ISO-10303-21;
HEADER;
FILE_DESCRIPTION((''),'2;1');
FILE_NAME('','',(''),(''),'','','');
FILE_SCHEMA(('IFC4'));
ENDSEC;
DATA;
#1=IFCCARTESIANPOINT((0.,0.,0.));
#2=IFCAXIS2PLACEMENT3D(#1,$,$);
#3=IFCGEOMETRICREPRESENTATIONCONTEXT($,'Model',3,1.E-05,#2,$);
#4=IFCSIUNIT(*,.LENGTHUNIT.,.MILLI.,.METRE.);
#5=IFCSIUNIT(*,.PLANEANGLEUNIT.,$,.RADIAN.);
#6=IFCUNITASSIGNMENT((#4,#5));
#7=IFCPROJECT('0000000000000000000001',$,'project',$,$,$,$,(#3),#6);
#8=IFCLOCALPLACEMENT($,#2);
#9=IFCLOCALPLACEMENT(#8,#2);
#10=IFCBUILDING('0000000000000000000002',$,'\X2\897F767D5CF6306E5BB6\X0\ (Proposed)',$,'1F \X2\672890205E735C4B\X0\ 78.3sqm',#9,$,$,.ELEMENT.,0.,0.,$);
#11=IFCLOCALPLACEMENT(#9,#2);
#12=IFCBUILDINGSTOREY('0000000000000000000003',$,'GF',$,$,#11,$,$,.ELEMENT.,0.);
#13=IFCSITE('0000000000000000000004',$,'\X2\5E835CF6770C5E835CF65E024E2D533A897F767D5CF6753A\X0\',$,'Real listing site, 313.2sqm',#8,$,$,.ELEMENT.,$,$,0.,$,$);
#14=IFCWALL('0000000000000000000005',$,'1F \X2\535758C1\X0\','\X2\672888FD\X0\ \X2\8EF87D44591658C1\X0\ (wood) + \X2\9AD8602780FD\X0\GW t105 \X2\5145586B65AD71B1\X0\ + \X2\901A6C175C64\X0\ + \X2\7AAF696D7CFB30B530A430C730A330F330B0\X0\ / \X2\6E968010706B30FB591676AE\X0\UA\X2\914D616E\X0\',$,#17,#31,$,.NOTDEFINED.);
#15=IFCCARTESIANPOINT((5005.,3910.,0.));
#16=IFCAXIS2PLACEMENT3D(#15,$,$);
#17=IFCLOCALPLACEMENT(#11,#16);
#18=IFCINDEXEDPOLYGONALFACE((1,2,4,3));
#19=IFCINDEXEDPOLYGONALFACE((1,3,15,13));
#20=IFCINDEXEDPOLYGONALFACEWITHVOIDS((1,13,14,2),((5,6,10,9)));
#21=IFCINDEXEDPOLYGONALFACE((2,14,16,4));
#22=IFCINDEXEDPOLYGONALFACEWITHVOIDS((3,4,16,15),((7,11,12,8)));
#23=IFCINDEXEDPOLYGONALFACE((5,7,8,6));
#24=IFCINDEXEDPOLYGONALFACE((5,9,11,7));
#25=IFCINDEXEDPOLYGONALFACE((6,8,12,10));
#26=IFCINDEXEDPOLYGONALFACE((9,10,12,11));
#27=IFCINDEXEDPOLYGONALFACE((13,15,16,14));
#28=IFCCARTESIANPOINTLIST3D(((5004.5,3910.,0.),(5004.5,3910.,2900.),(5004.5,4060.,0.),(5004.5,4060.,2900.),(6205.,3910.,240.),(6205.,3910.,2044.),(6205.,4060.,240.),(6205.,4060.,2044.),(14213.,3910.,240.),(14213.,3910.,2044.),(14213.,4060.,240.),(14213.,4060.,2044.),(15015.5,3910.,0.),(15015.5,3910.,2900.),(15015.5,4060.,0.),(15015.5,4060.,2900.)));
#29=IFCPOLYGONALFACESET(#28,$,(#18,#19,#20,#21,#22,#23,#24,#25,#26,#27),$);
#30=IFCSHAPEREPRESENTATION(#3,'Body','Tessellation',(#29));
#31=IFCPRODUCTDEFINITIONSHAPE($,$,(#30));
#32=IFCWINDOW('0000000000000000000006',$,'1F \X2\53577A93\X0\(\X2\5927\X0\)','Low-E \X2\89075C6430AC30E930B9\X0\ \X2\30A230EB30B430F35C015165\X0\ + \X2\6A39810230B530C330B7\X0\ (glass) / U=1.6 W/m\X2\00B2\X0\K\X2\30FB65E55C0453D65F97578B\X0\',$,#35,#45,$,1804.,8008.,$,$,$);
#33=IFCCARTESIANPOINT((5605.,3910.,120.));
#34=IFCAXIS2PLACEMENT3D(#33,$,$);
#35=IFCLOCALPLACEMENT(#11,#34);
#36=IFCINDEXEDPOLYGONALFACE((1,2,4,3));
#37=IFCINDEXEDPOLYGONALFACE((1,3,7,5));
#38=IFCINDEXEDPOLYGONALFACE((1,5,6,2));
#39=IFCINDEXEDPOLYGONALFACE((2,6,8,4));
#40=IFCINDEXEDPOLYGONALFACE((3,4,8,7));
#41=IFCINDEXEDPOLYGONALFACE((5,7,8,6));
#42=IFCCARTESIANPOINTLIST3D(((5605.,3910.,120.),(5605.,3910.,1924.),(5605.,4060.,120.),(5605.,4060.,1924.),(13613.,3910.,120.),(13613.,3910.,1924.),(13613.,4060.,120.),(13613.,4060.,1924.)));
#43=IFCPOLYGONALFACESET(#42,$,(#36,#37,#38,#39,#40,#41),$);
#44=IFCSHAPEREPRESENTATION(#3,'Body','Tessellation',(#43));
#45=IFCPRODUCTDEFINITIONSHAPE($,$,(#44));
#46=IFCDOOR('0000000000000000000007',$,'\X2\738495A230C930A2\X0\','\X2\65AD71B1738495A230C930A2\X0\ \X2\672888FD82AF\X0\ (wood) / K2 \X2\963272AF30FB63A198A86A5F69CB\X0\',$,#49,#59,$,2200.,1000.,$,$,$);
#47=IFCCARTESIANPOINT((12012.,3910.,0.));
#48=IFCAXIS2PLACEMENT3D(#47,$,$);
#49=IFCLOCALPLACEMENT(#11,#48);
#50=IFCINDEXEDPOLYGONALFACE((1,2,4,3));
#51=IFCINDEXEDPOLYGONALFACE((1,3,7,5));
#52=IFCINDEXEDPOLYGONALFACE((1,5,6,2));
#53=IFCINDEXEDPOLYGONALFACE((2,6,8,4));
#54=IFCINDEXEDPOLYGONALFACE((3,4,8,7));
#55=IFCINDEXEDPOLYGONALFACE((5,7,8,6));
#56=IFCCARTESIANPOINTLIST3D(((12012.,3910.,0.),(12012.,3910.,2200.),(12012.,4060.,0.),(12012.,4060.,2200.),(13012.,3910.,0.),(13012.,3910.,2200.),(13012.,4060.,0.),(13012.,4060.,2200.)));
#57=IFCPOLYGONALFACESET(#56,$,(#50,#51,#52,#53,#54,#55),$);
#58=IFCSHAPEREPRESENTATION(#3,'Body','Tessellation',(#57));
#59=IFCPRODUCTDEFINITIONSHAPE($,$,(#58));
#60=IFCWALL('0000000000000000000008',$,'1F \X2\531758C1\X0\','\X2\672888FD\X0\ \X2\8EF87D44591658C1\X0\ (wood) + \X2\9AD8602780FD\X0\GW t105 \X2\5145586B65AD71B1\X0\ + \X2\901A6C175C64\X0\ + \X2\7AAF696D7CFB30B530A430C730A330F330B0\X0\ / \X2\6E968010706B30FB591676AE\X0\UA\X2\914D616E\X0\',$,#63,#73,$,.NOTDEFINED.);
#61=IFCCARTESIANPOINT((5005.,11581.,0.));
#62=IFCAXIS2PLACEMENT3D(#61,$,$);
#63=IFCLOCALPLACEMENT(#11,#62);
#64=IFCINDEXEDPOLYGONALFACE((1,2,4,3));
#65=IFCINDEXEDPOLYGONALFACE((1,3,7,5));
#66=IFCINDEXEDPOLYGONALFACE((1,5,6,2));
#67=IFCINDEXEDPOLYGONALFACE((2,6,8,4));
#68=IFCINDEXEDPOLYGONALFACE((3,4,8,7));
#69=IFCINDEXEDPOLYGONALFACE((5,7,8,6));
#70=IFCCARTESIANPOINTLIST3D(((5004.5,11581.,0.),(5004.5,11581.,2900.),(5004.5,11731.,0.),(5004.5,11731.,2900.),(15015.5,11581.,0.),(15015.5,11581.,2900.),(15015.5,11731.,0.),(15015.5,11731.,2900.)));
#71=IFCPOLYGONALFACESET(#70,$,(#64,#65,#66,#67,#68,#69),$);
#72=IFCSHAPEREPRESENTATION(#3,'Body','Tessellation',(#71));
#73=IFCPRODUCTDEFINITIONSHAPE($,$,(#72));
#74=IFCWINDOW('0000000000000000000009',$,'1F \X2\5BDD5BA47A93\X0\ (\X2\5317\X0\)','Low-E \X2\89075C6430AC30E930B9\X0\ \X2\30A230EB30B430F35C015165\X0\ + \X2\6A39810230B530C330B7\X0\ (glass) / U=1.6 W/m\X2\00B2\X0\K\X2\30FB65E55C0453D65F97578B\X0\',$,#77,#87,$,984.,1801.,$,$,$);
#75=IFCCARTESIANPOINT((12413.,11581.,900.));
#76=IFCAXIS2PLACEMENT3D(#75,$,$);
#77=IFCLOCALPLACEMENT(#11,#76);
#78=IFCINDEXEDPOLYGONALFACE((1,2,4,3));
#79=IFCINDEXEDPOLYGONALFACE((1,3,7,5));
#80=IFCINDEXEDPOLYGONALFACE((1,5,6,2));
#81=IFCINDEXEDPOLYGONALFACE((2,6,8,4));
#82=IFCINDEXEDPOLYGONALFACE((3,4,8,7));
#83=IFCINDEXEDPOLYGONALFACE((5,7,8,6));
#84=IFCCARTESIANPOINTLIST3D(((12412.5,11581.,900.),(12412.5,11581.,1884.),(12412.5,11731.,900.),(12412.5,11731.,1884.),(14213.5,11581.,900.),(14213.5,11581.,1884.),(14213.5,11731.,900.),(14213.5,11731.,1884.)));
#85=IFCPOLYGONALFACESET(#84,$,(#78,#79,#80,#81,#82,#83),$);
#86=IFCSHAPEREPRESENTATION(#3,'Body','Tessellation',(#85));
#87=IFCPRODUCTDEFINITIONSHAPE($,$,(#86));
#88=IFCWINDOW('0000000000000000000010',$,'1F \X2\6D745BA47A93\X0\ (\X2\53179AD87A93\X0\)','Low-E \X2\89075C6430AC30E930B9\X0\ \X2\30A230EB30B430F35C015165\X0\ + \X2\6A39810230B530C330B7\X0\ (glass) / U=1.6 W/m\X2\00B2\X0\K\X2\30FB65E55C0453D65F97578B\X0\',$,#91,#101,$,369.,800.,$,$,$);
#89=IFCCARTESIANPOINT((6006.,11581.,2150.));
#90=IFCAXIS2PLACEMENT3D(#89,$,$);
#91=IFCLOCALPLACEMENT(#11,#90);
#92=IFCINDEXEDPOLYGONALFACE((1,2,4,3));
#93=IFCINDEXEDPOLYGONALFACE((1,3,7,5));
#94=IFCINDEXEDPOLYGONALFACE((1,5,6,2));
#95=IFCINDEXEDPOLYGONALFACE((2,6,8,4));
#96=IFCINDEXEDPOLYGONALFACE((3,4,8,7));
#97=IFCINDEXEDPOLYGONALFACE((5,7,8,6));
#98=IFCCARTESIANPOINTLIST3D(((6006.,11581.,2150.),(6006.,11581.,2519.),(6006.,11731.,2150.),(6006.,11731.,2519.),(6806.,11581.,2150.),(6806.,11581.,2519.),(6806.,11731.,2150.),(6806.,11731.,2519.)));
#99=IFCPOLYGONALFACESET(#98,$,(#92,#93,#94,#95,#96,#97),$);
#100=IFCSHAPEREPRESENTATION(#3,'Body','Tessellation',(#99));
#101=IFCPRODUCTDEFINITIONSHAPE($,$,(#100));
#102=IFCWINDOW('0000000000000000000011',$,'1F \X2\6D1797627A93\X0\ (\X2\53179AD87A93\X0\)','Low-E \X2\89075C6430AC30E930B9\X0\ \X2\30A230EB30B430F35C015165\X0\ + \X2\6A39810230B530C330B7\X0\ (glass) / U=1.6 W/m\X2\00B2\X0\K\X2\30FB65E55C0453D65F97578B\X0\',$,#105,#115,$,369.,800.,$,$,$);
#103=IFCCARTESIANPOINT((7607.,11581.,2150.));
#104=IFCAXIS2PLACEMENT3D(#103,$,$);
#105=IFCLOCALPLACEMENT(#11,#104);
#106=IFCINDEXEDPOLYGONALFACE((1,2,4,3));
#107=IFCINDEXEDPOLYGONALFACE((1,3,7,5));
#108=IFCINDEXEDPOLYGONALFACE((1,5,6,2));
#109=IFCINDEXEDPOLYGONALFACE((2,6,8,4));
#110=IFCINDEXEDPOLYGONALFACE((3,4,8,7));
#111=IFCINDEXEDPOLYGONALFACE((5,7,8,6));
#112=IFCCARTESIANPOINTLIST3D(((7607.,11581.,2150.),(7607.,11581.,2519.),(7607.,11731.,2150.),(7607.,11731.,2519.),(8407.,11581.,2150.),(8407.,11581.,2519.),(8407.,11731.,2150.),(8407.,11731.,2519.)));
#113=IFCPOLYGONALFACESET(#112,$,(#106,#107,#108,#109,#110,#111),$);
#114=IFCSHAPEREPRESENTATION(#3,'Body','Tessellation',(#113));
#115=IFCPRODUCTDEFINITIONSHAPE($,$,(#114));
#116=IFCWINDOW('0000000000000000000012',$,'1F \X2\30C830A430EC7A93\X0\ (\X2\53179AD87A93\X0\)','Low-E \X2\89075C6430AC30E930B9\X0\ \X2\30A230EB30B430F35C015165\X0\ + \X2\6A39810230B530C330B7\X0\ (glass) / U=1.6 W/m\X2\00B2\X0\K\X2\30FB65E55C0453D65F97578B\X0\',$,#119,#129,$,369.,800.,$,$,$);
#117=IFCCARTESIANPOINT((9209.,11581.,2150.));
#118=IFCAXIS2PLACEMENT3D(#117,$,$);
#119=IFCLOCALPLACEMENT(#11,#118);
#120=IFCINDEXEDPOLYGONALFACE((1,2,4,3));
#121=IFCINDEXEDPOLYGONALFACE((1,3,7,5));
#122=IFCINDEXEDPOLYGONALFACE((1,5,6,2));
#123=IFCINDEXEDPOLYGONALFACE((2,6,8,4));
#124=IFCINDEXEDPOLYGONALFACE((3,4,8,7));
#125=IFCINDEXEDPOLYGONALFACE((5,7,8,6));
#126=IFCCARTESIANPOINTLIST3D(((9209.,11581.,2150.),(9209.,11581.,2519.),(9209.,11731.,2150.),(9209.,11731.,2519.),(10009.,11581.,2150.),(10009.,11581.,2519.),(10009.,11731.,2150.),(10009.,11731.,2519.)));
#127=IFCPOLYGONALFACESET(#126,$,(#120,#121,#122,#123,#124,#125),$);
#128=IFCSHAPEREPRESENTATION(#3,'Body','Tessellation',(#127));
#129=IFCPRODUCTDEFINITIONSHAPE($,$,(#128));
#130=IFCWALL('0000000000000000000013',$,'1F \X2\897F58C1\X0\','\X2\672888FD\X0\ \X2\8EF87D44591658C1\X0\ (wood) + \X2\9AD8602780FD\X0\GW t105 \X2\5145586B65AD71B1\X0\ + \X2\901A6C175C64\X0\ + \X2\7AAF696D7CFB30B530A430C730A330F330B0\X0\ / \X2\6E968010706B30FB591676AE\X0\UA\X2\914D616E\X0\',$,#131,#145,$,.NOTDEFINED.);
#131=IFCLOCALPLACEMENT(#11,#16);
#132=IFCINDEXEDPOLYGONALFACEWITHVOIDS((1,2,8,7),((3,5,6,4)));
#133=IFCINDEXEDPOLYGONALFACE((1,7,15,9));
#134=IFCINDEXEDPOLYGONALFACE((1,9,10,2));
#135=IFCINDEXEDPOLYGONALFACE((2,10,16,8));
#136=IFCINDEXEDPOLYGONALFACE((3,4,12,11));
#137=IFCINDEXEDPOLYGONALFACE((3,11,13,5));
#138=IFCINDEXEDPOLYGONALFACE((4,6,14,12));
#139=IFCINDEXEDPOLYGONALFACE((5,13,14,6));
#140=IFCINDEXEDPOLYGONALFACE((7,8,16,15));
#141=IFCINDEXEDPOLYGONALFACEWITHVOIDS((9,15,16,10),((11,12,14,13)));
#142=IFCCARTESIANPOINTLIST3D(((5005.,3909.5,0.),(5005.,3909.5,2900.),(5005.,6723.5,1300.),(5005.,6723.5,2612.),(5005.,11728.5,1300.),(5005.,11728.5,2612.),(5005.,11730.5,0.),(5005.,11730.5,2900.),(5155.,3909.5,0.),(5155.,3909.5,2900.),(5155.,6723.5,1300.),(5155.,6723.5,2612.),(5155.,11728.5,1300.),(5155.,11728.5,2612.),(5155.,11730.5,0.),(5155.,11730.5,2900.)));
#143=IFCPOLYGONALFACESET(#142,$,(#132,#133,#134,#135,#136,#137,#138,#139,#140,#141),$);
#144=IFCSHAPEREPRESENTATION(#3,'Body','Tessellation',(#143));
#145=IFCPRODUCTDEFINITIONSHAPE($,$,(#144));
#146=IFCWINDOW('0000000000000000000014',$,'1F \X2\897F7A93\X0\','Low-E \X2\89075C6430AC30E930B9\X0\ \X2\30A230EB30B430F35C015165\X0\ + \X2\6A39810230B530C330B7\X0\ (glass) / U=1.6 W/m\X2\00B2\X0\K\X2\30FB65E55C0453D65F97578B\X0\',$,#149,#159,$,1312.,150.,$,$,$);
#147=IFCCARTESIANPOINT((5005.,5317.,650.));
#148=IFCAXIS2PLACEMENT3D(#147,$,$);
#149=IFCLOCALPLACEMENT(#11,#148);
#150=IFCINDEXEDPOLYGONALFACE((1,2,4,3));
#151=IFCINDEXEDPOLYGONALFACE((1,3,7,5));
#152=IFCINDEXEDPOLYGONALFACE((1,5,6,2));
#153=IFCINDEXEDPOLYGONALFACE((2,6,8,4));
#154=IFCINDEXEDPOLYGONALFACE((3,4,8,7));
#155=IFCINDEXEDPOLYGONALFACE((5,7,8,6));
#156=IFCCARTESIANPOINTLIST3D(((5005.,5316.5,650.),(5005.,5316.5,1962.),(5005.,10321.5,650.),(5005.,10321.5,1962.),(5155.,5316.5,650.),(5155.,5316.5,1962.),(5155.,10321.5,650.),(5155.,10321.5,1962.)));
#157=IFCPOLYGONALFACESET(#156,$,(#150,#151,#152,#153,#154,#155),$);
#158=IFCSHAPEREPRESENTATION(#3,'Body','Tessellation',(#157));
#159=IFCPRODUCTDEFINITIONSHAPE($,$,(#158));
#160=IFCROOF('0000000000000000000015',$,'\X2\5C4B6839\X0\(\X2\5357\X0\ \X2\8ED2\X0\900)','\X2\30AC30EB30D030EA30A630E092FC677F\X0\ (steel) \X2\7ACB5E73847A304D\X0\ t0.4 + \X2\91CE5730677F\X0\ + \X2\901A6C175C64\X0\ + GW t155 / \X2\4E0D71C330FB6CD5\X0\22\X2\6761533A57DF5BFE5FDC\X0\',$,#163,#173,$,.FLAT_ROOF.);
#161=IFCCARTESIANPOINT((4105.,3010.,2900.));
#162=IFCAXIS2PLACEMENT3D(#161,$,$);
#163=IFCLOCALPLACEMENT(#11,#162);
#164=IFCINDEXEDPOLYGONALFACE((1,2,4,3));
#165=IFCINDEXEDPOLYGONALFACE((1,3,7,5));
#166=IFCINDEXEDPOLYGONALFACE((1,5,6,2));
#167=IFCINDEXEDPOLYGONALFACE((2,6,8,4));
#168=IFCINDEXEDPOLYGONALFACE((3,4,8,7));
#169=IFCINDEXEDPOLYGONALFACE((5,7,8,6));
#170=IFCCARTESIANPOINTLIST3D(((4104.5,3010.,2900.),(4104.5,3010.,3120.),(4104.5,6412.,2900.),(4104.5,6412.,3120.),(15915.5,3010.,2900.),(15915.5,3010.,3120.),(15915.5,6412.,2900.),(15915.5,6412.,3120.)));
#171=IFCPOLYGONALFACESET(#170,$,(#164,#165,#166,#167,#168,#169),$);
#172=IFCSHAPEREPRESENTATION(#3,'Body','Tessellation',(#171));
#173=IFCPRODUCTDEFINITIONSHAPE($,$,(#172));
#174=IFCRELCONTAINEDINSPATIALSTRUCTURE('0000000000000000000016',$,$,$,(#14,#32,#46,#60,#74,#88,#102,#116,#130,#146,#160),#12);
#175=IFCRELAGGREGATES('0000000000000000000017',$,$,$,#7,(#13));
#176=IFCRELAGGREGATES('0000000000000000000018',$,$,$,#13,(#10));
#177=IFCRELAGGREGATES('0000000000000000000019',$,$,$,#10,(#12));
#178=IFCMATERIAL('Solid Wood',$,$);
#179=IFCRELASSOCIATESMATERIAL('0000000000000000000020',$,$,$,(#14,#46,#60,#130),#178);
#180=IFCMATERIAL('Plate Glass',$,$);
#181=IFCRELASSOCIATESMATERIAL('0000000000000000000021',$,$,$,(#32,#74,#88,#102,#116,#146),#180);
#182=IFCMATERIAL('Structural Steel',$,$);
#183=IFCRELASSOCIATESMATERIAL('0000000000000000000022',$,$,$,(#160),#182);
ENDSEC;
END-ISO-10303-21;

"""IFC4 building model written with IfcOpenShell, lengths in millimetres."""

from ifc_helpers import new_model, si_unit, frame, frame_2d, origin, place, context, project, spatial, rectangle, extrude, material, element, fill, save


model = new_model("IFC4")

# Units and contexts
model_context = context("Model", 3, precision=1e-05, world=origin())
ifc_project = project(units=[si_unit("LENGTHUNIT", "METRE", prefix="MILLI"), si_unit("PLANEANGLEUNIT", "RADIAN")], contexts=[model_context])

# Site, building, storey
site_placement = place(None, origin())
site = spatial("IfcSite", under=ifc_project, at=site_placement, Name="広島県広島市中区西白島町", ObjectType="Real listing site, 313.2sqm", CompositionType="ELEMENT", RefElevation=0.0)
building_placement = place(site_placement, origin())
building = spatial("IfcBuilding", under=site, at=building_placement, Name="西白島の家 (Proposed)", ObjectType="1F 木造平屋 78.3sqm", CompositionType="ELEMENT", ElevationOfRefHeight=0.0, ElevationOfTerrain=0.0)
storey_placement = place(building_placement, origin())
storey = spatial("IfcBuildingStorey", under=building, at=storey_placement, Name="GF", CompositionType="ELEMENT", Elevation=0.0)

# Shared definitions
ifc_material_1 = material(Name="Solid Wood")

# Wall, openings, window, door
wall_1_placement = place(storey_placement, frame((5005.0, 3910.0, 0.0)))
wall_1 = element("IfcWall", 1, at=wall_1_placement, inside=storey, material=ifc_material_1, Name="1F 南壁", Description="木製 軸組外壁 (wood) + 高性能GW t105 充填断熱 + 通気層 + 窯業系サイディング / 準耐火・外皮UA配慮", PredefinedType="NOTDEFINED", context=model_context, shape_type="SweptSolid", body=[
    extrude(rectangle(XDim=10011.0, YDim=150.0, at=frame_2d((5005.0, 75.0))), frame((5005.0, 3910.0, 0.0)), (0.0, 0.0, 1.0), 2900.0),
])
opening_1_placement = place(storey_placement, frame((5605.0, 3910.0, 120.0)))
opening_1 = element("IfcOpeningElement", 2, at=opening_1_placement, cuts=wall_1, PredefinedType="NOTDEFINED", context=model_context, shape_type="SweptSolid", body=[
    extrude(rectangle(XDim=8008.0, YDim=150.0, at=frame_2d((4004.0, 75.0))), frame((5605.0, 3910.0, 120.0)), (0.0, 0.0, 1.0), 1804.0),
])
opening_2_placement = place(storey_placement, frame((12012.0, 3910.0, 0.0)))
opening_2 = element("IfcOpeningElement", 3, at=opening_2_placement, cuts=wall_1, PredefinedType="NOTDEFINED", context=model_context, shape_type="SweptSolid", body=[
    extrude(rectangle(XDim=1000.0, YDim=150.0, at=frame_2d((500.0, 75.0))), frame((12012.0, 3910.0, 0.0)), (0.0, 0.0, 1.0), 2200.0),
])
ifc_material_2 = material(Name="Plate Glass")
window_1_placement = place(storey_placement, frame((5605.0, 3910.0, 120.0)))
window_1 = element("IfcWindow", 4, at=window_1_placement, inside=storey, material=ifc_material_2, Name="1F 南窓(大)", Description="Low-E 複層ガラス アルゴン封入 + 樹脂サッシ (glass) / U=1.6 W/m²K・日射取得型", OverallHeight=1804.0, OverallWidth=8008.0, context=model_context, shape_type="SweptSolid", body=[
    extrude(rectangle(XDim=8008.0, YDim=150.0, at=frame_2d((4004.0, 75.0))), frame((5605.0, 3910.0, 120.0)), (0.0, 0.0, 1.0), 1804.0),
])
fill(opening_1, window_1)
door_1_placement = place(storey_placement, frame((12012.0, 3910.0, 0.0)))
door_1 = element("IfcDoor", 5, at=door_1_placement, inside=storey, material=ifc_material_1, Name="玄関ドア", Description="断熱玄関ドア 木製芯 (wood) / K2 防犯・採風機構", OverallHeight=2200.0, OverallWidth=1000.0, context=model_context, shape_type="SweptSolid", body=[
    extrude(rectangle(XDim=1000.0, YDim=150.0, at=frame_2d((500.0, 75.0))), frame((12012.0, 3910.0, 0.0)), (0.0, 0.0, 1.0), 2200.0),
])
fill(opening_2, door_1)

# Wall, openings, windows
wall_2_placement = place(storey_placement, frame((5005.0, 11581.0, 0.0)))
wall_2 = element("IfcWall", 6, at=wall_2_placement, inside=storey, material=ifc_material_1, Name="1F 北壁", Description="木製 軸組外壁 (wood) + 高性能GW t105 充填断熱 + 通気層 + 窯業系サイディング / 準耐火・外皮UA配慮", PredefinedType="NOTDEFINED", context=model_context, shape_type="SweptSolid", body=[
    extrude(rectangle(XDim=10011.0, YDim=150.0, at=frame_2d((5005.0, 75.0))), frame((5005.0, 11581.0, 0.0)), (0.0, 0.0, 1.0), 2900.0),
])
opening_3_placement = place(storey_placement, frame((12413.0, 11581.0, 900.0)))
opening_3 = element("IfcOpeningElement", 7, at=opening_3_placement, cuts=wall_2, PredefinedType="NOTDEFINED", context=model_context, shape_type="SweptSolid", body=[
    extrude(rectangle(XDim=1801.0, YDim=150.0, at=frame_2d((900.0, 75.0))), frame((12413.0, 11581.0, 900.0)), (0.0, 0.0, 1.0), 984.0),
])
opening_4_placement = place(storey_placement, frame((6006.0, 11581.0, 2150.0)))
opening_4 = element("IfcOpeningElement", 8, at=opening_4_placement, cuts=wall_2, PredefinedType="NOTDEFINED", context=model_context, shape_type="SweptSolid", body=[
    extrude(rectangle(XDim=800.0, YDim=150.0, at=frame_2d((400.0, 75.0))), frame((6006.0, 11581.0, 2150.0)), (0.0, 0.0, 1.0), 369.0),
])
opening_5_placement = place(storey_placement, frame((7607.0, 11581.0, 2150.0)))
opening_5 = element("IfcOpeningElement", 9, at=opening_5_placement, cuts=wall_2, PredefinedType="NOTDEFINED", context=model_context, shape_type="SweptSolid", body=[
    extrude(rectangle(XDim=800.0, YDim=150.0, at=frame_2d((400.0, 75.0))), frame((7607.0, 11581.0, 2150.0)), (0.0, 0.0, 1.0), 369.0),
])
opening_6_placement = place(storey_placement, frame((9209.0, 11581.0, 2150.0)))
opening_6 = element("IfcOpeningElement", 10, at=opening_6_placement, cuts=wall_2, PredefinedType="NOTDEFINED", context=model_context, shape_type="SweptSolid", body=[
    extrude(rectangle(XDim=800.0, YDim=150.0, at=frame_2d((400.0, 75.0))), frame((9209.0, 11581.0, 2150.0)), (0.0, 0.0, 1.0), 369.0),
])
window_2_placement = place(storey_placement, frame((12413.0, 11581.0, 900.0)))
window_2 = element("IfcWindow", 11, at=window_2_placement, inside=storey, material=ifc_material_2, Name="1F 寝室窓 (北)", Description="Low-E 複層ガラス アルゴン封入 + 樹脂サッシ (glass) / U=1.6 W/m²K・日射取得型", OverallHeight=984.0, OverallWidth=1801.0, context=model_context, shape_type="SweptSolid", body=[
    extrude(rectangle(XDim=1801.0, YDim=150.0, at=frame_2d((900.0, 75.0))), frame((12413.0, 11581.0, 900.0)), (0.0, 0.0, 1.0), 984.0),
])
fill(opening_3, window_2)
window_3_placement = place(storey_placement, frame((6006.0, 11581.0, 2150.0)))
window_3 = element("IfcWindow", 12, at=window_3_placement, inside=storey, material=ifc_material_2, Name="1F 浴室窓 (北高窓)", Description="Low-E 複層ガラス アルゴン封入 + 樹脂サッシ (glass) / U=1.6 W/m²K・日射取得型", OverallHeight=369.0, OverallWidth=800.0, context=model_context, shape_type="SweptSolid", body=[
    extrude(rectangle(XDim=800.0, YDim=150.0, at=frame_2d((400.0, 75.0))), frame((6006.0, 11581.0, 2150.0)), (0.0, 0.0, 1.0), 369.0),
])
fill(opening_4, window_3)
window_4_placement = place(storey_placement, frame((7607.0, 11581.0, 2150.0)))
window_4 = element("IfcWindow", 13, at=window_4_placement, inside=storey, material=ifc_material_2, Name="1F 洗面窓 (北高窓)", Description="Low-E 複層ガラス アルゴン封入 + 樹脂サッシ (glass) / U=1.6 W/m²K・日射取得型", OverallHeight=369.0, OverallWidth=800.0, context=model_context, shape_type="SweptSolid", body=[
    extrude(rectangle(XDim=800.0, YDim=150.0, at=frame_2d((400.0, 75.0))), frame((7607.0, 11581.0, 2150.0)), (0.0, 0.0, 1.0), 369.0),
])
fill(opening_5, window_4)
window_5_placement = place(storey_placement, frame((9209.0, 11581.0, 2150.0)))
window_5 = element("IfcWindow", 14, at=window_5_placement, inside=storey, material=ifc_material_2, Name="1F トイレ窓 (北高窓)", Description="Low-E 複層ガラス アルゴン封入 + 樹脂サッシ (glass) / U=1.6 W/m²K・日射取得型", OverallHeight=369.0, OverallWidth=800.0, context=model_context, shape_type="SweptSolid", body=[
    extrude(rectangle(XDim=800.0, YDim=150.0, at=frame_2d((400.0, 75.0))), frame((9209.0, 11581.0, 2150.0)), (0.0, 0.0, 1.0), 369.0),
])
fill(opening_6, window_5)

# Wall, opening, window
wall_3_placement = place(storey_placement, frame((5005.0, 3910.0, 0.0)))
wall_3 = element("IfcWall", 15, at=wall_3_placement, inside=storey, material=ifc_material_1, Name="1F 西壁", Description="木製 軸組外壁 (wood) + 高性能GW t105 充填断熱 + 通気層 + 窯業系サイディング / 準耐火・外皮UA配慮", PredefinedType="NOTDEFINED", context=model_context, shape_type="SweptSolid", body=[
    extrude(rectangle(XDim=150.0, YDim=7821.0, at=frame_2d((75.0, 3910.0))), frame((5005.0, 3910.0, 0.0)), (0.0, 0.0, 1.0), 2900.0),
])
opening_7_placement = place(storey_placement, frame((5005.0, 5317.0, 650.0)))
opening_7 = element("IfcOpeningElement", 16, at=opening_7_placement, cuts=wall_3, PredefinedType="NOTDEFINED", context=model_context, shape_type="SweptSolid", body=[
    extrude(rectangle(XDim=150.0, YDim=5005.0, at=frame_2d((75.0, 2502.0))), frame((5005.0, 5317.0, 650.0)), (0.0, 0.0, 1.0), 1312.0),
])
window_6_placement = place(storey_placement, frame((5005.0, 5317.0, 650.0)))
window_6 = element("IfcWindow", 17, at=window_6_placement, inside=storey, material=ifc_material_2, Name="1F 西窓", Description="Low-E 複層ガラス アルゴン封入 + 樹脂サッシ (glass) / U=1.6 W/m²K・日射取得型", OverallHeight=1312.0, OverallWidth=150.0, context=model_context, shape_type="SweptSolid", body=[
    extrude(rectangle(XDim=150.0, YDim=5005.0, at=frame_2d((75.0, 2502.0))), frame((5005.0, 5317.0, 650.0)), (0.0, 0.0, 1.0), 1312.0),
])
fill(opening_7, window_6)

# Roof
ifc_material_3 = material(Name="Structural Steel")
roof_1_placement = place(storey_placement, frame((4105.0, 3010.0, 2900.0)))
element("IfcRoof", 18, at=roof_1_placement, inside=storey, material=ifc_material_3, Name="屋根(南 軒900)", Description="ガルバリウム鋼板 (steel) 立平葺き t0.4 + 野地板 + 通気層 + GW t155 / 不燃・法22条区域対応", PredefinedType="FLAT_ROOF", context=model_context, shape_type="SweptSolid", body=[
    extrude(rectangle(XDim=11811.0, YDim=3402.0, at=frame_2d((5905.0, 1701.0))), frame((4105.0, 3010.0, 2900.0)), (0.0, 0.0, 1.0), 220.0),
])

save(model, "model.ifc")
